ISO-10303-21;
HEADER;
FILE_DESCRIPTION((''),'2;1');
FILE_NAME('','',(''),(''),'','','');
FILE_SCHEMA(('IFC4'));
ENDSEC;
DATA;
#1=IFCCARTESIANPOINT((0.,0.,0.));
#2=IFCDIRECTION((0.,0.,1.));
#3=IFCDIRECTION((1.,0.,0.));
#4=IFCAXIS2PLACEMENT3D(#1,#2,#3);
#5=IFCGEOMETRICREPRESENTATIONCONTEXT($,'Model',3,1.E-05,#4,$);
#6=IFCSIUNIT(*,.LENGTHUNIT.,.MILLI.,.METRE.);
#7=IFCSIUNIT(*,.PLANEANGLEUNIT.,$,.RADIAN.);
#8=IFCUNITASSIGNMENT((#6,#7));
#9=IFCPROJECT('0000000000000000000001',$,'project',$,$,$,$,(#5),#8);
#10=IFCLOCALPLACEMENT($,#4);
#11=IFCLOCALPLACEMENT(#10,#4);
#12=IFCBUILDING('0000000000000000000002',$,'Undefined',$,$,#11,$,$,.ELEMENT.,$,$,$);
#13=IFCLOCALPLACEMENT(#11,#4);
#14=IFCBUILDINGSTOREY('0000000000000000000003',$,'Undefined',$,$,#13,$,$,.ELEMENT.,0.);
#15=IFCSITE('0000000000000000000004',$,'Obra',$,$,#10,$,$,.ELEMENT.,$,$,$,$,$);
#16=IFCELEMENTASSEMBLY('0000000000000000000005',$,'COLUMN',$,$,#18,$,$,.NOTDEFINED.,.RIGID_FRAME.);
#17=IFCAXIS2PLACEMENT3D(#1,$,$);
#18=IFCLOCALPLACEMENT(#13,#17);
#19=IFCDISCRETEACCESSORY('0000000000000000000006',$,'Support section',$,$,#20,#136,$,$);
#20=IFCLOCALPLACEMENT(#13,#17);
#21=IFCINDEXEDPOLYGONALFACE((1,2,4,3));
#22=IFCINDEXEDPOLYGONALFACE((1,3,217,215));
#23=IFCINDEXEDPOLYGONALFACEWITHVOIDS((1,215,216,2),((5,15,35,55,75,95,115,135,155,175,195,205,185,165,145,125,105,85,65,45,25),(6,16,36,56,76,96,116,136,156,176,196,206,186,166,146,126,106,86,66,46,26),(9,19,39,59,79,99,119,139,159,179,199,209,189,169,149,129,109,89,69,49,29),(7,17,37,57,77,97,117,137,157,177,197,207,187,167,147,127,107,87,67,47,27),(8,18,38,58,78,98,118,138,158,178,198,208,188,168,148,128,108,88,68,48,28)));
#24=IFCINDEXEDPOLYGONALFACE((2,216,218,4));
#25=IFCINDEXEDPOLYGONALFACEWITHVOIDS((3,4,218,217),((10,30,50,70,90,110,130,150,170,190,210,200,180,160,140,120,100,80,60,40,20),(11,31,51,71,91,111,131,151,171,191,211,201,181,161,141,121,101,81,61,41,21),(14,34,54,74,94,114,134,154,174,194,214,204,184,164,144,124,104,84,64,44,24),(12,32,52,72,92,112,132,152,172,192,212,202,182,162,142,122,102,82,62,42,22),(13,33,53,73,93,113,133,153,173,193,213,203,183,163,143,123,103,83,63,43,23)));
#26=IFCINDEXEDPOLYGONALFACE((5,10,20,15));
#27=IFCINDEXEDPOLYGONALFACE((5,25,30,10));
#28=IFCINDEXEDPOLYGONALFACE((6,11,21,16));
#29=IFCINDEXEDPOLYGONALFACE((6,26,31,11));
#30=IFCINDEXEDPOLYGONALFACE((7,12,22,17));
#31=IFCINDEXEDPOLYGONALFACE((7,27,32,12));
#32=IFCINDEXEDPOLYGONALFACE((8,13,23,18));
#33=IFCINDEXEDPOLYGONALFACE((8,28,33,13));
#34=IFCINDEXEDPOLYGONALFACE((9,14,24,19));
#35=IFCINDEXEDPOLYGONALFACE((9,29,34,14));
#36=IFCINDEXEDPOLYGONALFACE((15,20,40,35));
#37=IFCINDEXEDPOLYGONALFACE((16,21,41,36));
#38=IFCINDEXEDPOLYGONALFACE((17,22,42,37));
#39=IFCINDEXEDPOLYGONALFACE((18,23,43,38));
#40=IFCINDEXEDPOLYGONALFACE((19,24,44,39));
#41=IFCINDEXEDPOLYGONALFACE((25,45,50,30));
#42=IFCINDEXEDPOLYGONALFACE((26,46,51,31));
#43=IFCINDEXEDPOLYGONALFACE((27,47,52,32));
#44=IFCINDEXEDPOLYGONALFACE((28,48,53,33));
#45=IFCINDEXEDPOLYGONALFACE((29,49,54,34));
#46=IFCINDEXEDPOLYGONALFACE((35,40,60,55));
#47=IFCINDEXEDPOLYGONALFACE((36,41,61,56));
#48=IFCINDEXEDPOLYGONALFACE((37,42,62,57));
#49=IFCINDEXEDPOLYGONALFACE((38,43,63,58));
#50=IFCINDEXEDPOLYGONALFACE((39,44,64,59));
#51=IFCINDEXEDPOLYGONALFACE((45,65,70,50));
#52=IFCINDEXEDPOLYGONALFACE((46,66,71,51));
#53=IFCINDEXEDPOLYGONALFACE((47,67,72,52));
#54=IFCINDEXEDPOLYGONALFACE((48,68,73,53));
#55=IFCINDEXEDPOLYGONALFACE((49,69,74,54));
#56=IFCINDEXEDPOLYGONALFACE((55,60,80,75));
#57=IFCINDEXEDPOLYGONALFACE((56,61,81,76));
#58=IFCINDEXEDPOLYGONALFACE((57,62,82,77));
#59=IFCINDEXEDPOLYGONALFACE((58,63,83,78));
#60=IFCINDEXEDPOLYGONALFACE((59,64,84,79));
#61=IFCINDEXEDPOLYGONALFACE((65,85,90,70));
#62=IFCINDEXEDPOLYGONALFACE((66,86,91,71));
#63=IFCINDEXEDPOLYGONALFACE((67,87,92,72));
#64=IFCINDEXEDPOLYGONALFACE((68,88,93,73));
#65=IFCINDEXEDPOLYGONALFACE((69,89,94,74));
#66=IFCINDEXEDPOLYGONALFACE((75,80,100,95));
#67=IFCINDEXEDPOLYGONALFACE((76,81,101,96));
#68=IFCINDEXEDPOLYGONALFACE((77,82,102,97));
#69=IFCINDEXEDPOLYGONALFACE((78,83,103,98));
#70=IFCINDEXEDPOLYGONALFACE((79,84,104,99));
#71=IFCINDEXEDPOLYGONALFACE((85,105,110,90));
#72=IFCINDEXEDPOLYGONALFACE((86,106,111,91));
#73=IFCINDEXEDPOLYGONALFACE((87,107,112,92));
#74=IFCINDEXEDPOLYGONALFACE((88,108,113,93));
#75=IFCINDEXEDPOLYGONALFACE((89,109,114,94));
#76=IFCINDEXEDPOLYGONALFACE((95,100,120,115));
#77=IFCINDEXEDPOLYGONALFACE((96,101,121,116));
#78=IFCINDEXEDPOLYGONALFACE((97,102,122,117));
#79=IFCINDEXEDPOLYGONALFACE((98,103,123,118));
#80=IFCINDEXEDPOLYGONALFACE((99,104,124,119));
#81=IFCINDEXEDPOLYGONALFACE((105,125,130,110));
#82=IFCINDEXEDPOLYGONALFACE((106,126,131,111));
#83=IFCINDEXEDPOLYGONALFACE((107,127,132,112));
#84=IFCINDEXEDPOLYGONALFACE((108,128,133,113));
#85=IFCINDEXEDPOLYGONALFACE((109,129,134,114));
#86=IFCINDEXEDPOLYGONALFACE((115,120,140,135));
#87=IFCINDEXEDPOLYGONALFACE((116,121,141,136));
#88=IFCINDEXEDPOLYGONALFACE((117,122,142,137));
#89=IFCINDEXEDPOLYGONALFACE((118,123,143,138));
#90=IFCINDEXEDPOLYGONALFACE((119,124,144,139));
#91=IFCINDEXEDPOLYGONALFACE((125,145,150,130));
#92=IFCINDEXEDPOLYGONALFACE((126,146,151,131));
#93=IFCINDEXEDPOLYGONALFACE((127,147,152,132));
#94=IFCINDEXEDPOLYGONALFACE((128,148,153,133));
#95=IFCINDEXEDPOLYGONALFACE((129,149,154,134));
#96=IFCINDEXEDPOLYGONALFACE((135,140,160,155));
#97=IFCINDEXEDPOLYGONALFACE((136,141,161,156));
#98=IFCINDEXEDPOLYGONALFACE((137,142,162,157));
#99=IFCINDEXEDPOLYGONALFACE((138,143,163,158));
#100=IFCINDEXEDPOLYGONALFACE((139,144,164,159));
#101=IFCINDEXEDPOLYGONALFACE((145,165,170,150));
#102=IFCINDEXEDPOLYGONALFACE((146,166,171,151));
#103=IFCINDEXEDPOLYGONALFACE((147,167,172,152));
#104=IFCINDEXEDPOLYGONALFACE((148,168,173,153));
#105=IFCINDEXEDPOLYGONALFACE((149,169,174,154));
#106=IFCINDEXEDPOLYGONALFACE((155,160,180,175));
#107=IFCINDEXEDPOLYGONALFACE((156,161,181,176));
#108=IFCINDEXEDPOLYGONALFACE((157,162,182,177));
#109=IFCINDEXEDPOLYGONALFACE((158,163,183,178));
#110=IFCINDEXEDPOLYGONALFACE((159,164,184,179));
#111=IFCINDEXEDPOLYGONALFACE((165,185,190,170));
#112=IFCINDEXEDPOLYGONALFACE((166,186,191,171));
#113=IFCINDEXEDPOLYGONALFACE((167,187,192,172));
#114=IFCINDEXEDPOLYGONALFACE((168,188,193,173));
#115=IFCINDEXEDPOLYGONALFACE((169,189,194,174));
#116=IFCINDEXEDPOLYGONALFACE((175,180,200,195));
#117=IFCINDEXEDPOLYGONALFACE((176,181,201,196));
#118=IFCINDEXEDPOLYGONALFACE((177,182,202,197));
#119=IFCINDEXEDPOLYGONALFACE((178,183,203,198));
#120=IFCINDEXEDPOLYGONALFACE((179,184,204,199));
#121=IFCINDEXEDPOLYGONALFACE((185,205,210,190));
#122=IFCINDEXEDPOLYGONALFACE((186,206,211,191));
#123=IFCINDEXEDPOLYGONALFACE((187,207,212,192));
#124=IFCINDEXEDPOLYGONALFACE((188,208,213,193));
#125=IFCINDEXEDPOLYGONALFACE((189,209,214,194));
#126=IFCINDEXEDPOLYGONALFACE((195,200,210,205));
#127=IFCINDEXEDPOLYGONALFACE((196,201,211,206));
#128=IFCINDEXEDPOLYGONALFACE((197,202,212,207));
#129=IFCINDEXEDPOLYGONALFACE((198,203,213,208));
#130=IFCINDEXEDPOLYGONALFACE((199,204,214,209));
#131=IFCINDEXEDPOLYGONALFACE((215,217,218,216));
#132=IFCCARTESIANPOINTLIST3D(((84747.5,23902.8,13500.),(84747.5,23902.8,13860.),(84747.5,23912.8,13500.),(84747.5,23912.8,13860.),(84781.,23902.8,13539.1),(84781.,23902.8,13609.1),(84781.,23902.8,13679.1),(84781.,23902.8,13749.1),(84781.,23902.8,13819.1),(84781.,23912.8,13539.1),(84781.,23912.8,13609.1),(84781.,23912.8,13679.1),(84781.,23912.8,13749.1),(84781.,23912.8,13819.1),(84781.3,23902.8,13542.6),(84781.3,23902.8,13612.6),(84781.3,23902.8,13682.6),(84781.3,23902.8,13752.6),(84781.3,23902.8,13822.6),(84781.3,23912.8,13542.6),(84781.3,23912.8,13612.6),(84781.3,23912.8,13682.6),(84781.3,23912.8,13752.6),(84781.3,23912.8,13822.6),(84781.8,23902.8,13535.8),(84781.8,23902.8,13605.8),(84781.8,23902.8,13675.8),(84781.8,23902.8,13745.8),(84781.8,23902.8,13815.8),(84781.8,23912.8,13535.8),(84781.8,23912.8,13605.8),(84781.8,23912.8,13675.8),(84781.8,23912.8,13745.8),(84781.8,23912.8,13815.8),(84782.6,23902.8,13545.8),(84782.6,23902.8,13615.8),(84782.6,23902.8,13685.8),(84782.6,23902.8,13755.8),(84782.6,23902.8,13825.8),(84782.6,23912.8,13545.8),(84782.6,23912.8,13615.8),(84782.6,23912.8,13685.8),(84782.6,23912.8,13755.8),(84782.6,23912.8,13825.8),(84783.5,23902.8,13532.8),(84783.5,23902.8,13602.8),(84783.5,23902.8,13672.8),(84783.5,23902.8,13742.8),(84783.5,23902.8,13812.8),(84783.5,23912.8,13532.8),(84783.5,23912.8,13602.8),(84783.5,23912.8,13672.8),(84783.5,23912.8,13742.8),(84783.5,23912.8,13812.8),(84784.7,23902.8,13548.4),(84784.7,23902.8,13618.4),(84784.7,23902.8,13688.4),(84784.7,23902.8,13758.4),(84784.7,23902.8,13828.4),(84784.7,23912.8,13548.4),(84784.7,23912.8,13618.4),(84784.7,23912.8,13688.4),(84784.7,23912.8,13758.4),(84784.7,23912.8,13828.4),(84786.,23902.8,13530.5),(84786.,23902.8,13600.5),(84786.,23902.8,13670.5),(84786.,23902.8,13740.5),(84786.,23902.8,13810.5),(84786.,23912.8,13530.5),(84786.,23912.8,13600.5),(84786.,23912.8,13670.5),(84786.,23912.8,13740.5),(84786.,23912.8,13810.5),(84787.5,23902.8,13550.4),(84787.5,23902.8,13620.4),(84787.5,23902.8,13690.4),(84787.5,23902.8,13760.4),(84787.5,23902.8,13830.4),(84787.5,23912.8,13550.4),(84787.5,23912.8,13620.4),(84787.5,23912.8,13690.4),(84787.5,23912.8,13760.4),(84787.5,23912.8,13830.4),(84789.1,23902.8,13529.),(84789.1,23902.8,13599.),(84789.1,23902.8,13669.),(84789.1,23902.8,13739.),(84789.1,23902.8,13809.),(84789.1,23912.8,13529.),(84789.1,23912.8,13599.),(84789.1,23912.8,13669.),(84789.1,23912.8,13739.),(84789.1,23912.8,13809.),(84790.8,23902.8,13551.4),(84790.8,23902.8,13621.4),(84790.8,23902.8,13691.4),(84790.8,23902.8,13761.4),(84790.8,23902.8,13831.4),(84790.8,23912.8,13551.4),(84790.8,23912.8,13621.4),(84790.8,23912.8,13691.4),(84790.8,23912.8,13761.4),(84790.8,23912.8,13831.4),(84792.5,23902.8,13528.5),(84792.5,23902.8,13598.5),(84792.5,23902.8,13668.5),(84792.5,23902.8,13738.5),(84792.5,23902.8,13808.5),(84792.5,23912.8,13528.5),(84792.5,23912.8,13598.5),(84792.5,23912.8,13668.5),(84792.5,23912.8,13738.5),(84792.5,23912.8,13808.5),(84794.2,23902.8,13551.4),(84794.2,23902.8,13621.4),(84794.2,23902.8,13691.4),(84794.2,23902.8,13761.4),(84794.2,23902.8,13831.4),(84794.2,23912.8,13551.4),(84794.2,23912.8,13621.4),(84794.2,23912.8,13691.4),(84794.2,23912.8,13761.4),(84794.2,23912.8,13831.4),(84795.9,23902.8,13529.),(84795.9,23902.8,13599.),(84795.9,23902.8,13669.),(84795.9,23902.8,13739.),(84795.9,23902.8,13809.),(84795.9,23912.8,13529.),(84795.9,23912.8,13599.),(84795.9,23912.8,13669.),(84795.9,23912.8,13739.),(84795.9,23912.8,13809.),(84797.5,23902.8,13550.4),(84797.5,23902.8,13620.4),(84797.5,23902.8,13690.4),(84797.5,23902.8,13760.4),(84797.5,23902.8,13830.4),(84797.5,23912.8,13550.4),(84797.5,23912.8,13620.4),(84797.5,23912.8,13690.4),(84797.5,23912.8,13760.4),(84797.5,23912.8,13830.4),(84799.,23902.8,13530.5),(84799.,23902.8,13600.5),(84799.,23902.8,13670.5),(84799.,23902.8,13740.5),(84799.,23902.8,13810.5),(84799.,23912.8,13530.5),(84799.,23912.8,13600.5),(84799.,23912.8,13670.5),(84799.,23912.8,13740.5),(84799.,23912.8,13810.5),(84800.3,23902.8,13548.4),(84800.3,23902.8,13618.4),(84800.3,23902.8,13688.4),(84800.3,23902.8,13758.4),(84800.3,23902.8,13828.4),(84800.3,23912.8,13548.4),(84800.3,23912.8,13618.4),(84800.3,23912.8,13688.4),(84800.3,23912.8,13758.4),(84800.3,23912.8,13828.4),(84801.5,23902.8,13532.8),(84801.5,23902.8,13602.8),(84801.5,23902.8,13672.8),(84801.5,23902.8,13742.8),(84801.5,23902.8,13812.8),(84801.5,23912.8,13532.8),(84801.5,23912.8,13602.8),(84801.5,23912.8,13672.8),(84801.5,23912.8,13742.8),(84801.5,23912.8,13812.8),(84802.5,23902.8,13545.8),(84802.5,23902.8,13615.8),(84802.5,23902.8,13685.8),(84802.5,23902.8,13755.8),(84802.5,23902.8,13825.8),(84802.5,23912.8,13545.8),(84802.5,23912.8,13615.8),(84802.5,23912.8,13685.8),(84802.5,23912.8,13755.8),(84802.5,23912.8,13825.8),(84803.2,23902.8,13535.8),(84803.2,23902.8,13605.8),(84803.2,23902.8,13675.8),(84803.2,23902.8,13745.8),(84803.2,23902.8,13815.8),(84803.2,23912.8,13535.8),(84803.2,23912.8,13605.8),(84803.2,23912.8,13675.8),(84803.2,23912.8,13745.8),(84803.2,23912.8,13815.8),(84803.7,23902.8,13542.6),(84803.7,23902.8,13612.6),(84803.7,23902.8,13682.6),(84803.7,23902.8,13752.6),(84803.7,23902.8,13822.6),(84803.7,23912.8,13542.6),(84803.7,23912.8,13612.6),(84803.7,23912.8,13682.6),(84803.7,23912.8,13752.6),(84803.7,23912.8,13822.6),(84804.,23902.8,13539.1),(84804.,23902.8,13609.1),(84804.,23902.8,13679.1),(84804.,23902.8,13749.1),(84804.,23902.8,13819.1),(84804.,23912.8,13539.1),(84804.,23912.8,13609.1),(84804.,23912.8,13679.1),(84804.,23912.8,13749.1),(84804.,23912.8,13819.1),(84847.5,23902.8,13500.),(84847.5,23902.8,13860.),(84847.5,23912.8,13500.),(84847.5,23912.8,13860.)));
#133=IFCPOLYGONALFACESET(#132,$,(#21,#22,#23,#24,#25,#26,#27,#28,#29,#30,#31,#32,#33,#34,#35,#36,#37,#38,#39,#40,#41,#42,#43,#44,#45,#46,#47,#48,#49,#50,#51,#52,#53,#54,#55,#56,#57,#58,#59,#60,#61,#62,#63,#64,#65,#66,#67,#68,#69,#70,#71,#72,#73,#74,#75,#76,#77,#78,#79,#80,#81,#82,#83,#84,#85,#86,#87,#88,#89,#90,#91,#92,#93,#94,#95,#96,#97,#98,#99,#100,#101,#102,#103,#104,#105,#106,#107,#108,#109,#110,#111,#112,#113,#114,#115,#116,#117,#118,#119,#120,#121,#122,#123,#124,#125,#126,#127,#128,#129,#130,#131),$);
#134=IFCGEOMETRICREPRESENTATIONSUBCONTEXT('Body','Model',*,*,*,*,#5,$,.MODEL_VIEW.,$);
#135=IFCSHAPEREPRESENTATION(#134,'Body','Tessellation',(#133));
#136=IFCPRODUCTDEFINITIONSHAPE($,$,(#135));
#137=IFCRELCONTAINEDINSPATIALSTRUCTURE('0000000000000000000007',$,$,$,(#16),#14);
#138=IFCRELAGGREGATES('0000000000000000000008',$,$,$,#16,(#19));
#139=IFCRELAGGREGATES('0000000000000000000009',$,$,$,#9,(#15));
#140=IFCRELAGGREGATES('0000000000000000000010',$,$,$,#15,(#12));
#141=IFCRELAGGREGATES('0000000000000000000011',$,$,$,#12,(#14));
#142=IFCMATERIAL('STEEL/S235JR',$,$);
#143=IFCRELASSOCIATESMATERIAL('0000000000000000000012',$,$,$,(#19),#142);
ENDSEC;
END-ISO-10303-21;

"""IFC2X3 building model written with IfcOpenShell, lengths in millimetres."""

from ifc_helpers import new_model, si_unit, frame, origin_with_axes, origin_2d_with_axis, place, context, subcontext, project, spatial, rectangle, circle, extrude, source, transform, mapped, material, element, aggregate, save


model = new_model("IFC2X3")

# Units and contexts
model_context = context("Model", 3, precision=1e-05, world=origin_with_axes())
body_context = subcontext(model_context, "Body", "Model", "MODEL_VIEW")
ifc_project = project(units=[si_unit("LENGTHUNIT", "METRE", prefix="MILLI"), si_unit("PLANEANGLEUNIT", "RADIAN")], contexts=[model_context])

# Site, building, storey
site_placement = place(None, origin_with_axes())
site = spatial("IfcSite", under=ifc_project, at=site_placement, Name="Obra", CompositionType="ELEMENT")
building_placement = place(site_placement, origin_with_axes())
building = spatial("IfcBuilding", under=site, at=building_placement, Name="Undefined", CompositionType="ELEMENT")
storey_placement = place(building_placement, origin_with_axes())
storey = spatial("IfcBuildingStorey", under=building, at=storey_placement, Name="Undefined", CompositionType="ELEMENT", Elevation=0.0)

# Element assembly
assembly_1_placement = place(storey_placement, origin_with_axes())
assembly_1 = element("IfcElementAssembly", 1, at=assembly_1_placement, inside=storey, Name="COLUMN", AssemblyPlace="NOTDEFINED", PredefinedType="RIGID_FRAME")
ifc_material_1 = material(Name="STEEL/S235JR")

# Discrete accessory, opening
discrete_accessory_1_placement = place(assembly_1_placement, frame((84797.5, 23907.8, 13500.0), z_axis=(0.0, 0.0, 1.0), x_axis=(1.0, 0.0, 0.0)))
discrete_accessory_1 = element("IfcDiscreteAccessory", 2, at=discrete_accessory_1_placement, material=ifc_material_1, Name="Support section", context=body_context, shape_type="SweptSolid", body=[
    extrude(rectangle(XDim=10.0, YDim=100.0, at=origin_2d_with_axis()), frame((0.0, 0.0, 360.0), z_axis=(0.0, 0.0, -1.0), x_axis=(0.0, 1.0, 0.0)), (0.0, 0.0, 1.0), 360.0),
])
shared_shape_1 = source(origin_with_axes(), body_context, "Body", "SweptSolid", [
    extrude(circle(Radius=11.5, at=origin_2d_with_axis()), frame((0.0, -15.8, 0.0), z_axis=(0.0, 1.0, 0.0), x_axis=(1.0, 0.0, 0.0)), (0.0, 0.0, 1.0), 10.2),
])
opening_1_placement = place(assembly_1_placement, frame((84837.5, 23897.0, 13900.0), z_axis=(-1.0, 0.0, 0.0), x_axis=(0.0, 0.0, -1.0)))
element("IfcOpeningElement", 3, at=opening_1_placement, cuts=discrete_accessory_1, ObjectType="Opening", context=body_context, shape_type="MappedRepresentation", body=[
    mapped(shared_shape_1, transform((80.0, 0.0, 45.0))),
    mapped(shared_shape_1, transform((150.0, 0.0, 45.0))),
    mapped(shared_shape_1, transform((220.0, 0.0, 45.0))),
    mapped(shared_shape_1, transform((290.0, 0.0, 45.0))),
    mapped(shared_shape_1, transform((360.0, 0.0, 45.0))),
])
aggregate(assembly_1, [discrete_accessory_1])

save(model, "model.ifc")
